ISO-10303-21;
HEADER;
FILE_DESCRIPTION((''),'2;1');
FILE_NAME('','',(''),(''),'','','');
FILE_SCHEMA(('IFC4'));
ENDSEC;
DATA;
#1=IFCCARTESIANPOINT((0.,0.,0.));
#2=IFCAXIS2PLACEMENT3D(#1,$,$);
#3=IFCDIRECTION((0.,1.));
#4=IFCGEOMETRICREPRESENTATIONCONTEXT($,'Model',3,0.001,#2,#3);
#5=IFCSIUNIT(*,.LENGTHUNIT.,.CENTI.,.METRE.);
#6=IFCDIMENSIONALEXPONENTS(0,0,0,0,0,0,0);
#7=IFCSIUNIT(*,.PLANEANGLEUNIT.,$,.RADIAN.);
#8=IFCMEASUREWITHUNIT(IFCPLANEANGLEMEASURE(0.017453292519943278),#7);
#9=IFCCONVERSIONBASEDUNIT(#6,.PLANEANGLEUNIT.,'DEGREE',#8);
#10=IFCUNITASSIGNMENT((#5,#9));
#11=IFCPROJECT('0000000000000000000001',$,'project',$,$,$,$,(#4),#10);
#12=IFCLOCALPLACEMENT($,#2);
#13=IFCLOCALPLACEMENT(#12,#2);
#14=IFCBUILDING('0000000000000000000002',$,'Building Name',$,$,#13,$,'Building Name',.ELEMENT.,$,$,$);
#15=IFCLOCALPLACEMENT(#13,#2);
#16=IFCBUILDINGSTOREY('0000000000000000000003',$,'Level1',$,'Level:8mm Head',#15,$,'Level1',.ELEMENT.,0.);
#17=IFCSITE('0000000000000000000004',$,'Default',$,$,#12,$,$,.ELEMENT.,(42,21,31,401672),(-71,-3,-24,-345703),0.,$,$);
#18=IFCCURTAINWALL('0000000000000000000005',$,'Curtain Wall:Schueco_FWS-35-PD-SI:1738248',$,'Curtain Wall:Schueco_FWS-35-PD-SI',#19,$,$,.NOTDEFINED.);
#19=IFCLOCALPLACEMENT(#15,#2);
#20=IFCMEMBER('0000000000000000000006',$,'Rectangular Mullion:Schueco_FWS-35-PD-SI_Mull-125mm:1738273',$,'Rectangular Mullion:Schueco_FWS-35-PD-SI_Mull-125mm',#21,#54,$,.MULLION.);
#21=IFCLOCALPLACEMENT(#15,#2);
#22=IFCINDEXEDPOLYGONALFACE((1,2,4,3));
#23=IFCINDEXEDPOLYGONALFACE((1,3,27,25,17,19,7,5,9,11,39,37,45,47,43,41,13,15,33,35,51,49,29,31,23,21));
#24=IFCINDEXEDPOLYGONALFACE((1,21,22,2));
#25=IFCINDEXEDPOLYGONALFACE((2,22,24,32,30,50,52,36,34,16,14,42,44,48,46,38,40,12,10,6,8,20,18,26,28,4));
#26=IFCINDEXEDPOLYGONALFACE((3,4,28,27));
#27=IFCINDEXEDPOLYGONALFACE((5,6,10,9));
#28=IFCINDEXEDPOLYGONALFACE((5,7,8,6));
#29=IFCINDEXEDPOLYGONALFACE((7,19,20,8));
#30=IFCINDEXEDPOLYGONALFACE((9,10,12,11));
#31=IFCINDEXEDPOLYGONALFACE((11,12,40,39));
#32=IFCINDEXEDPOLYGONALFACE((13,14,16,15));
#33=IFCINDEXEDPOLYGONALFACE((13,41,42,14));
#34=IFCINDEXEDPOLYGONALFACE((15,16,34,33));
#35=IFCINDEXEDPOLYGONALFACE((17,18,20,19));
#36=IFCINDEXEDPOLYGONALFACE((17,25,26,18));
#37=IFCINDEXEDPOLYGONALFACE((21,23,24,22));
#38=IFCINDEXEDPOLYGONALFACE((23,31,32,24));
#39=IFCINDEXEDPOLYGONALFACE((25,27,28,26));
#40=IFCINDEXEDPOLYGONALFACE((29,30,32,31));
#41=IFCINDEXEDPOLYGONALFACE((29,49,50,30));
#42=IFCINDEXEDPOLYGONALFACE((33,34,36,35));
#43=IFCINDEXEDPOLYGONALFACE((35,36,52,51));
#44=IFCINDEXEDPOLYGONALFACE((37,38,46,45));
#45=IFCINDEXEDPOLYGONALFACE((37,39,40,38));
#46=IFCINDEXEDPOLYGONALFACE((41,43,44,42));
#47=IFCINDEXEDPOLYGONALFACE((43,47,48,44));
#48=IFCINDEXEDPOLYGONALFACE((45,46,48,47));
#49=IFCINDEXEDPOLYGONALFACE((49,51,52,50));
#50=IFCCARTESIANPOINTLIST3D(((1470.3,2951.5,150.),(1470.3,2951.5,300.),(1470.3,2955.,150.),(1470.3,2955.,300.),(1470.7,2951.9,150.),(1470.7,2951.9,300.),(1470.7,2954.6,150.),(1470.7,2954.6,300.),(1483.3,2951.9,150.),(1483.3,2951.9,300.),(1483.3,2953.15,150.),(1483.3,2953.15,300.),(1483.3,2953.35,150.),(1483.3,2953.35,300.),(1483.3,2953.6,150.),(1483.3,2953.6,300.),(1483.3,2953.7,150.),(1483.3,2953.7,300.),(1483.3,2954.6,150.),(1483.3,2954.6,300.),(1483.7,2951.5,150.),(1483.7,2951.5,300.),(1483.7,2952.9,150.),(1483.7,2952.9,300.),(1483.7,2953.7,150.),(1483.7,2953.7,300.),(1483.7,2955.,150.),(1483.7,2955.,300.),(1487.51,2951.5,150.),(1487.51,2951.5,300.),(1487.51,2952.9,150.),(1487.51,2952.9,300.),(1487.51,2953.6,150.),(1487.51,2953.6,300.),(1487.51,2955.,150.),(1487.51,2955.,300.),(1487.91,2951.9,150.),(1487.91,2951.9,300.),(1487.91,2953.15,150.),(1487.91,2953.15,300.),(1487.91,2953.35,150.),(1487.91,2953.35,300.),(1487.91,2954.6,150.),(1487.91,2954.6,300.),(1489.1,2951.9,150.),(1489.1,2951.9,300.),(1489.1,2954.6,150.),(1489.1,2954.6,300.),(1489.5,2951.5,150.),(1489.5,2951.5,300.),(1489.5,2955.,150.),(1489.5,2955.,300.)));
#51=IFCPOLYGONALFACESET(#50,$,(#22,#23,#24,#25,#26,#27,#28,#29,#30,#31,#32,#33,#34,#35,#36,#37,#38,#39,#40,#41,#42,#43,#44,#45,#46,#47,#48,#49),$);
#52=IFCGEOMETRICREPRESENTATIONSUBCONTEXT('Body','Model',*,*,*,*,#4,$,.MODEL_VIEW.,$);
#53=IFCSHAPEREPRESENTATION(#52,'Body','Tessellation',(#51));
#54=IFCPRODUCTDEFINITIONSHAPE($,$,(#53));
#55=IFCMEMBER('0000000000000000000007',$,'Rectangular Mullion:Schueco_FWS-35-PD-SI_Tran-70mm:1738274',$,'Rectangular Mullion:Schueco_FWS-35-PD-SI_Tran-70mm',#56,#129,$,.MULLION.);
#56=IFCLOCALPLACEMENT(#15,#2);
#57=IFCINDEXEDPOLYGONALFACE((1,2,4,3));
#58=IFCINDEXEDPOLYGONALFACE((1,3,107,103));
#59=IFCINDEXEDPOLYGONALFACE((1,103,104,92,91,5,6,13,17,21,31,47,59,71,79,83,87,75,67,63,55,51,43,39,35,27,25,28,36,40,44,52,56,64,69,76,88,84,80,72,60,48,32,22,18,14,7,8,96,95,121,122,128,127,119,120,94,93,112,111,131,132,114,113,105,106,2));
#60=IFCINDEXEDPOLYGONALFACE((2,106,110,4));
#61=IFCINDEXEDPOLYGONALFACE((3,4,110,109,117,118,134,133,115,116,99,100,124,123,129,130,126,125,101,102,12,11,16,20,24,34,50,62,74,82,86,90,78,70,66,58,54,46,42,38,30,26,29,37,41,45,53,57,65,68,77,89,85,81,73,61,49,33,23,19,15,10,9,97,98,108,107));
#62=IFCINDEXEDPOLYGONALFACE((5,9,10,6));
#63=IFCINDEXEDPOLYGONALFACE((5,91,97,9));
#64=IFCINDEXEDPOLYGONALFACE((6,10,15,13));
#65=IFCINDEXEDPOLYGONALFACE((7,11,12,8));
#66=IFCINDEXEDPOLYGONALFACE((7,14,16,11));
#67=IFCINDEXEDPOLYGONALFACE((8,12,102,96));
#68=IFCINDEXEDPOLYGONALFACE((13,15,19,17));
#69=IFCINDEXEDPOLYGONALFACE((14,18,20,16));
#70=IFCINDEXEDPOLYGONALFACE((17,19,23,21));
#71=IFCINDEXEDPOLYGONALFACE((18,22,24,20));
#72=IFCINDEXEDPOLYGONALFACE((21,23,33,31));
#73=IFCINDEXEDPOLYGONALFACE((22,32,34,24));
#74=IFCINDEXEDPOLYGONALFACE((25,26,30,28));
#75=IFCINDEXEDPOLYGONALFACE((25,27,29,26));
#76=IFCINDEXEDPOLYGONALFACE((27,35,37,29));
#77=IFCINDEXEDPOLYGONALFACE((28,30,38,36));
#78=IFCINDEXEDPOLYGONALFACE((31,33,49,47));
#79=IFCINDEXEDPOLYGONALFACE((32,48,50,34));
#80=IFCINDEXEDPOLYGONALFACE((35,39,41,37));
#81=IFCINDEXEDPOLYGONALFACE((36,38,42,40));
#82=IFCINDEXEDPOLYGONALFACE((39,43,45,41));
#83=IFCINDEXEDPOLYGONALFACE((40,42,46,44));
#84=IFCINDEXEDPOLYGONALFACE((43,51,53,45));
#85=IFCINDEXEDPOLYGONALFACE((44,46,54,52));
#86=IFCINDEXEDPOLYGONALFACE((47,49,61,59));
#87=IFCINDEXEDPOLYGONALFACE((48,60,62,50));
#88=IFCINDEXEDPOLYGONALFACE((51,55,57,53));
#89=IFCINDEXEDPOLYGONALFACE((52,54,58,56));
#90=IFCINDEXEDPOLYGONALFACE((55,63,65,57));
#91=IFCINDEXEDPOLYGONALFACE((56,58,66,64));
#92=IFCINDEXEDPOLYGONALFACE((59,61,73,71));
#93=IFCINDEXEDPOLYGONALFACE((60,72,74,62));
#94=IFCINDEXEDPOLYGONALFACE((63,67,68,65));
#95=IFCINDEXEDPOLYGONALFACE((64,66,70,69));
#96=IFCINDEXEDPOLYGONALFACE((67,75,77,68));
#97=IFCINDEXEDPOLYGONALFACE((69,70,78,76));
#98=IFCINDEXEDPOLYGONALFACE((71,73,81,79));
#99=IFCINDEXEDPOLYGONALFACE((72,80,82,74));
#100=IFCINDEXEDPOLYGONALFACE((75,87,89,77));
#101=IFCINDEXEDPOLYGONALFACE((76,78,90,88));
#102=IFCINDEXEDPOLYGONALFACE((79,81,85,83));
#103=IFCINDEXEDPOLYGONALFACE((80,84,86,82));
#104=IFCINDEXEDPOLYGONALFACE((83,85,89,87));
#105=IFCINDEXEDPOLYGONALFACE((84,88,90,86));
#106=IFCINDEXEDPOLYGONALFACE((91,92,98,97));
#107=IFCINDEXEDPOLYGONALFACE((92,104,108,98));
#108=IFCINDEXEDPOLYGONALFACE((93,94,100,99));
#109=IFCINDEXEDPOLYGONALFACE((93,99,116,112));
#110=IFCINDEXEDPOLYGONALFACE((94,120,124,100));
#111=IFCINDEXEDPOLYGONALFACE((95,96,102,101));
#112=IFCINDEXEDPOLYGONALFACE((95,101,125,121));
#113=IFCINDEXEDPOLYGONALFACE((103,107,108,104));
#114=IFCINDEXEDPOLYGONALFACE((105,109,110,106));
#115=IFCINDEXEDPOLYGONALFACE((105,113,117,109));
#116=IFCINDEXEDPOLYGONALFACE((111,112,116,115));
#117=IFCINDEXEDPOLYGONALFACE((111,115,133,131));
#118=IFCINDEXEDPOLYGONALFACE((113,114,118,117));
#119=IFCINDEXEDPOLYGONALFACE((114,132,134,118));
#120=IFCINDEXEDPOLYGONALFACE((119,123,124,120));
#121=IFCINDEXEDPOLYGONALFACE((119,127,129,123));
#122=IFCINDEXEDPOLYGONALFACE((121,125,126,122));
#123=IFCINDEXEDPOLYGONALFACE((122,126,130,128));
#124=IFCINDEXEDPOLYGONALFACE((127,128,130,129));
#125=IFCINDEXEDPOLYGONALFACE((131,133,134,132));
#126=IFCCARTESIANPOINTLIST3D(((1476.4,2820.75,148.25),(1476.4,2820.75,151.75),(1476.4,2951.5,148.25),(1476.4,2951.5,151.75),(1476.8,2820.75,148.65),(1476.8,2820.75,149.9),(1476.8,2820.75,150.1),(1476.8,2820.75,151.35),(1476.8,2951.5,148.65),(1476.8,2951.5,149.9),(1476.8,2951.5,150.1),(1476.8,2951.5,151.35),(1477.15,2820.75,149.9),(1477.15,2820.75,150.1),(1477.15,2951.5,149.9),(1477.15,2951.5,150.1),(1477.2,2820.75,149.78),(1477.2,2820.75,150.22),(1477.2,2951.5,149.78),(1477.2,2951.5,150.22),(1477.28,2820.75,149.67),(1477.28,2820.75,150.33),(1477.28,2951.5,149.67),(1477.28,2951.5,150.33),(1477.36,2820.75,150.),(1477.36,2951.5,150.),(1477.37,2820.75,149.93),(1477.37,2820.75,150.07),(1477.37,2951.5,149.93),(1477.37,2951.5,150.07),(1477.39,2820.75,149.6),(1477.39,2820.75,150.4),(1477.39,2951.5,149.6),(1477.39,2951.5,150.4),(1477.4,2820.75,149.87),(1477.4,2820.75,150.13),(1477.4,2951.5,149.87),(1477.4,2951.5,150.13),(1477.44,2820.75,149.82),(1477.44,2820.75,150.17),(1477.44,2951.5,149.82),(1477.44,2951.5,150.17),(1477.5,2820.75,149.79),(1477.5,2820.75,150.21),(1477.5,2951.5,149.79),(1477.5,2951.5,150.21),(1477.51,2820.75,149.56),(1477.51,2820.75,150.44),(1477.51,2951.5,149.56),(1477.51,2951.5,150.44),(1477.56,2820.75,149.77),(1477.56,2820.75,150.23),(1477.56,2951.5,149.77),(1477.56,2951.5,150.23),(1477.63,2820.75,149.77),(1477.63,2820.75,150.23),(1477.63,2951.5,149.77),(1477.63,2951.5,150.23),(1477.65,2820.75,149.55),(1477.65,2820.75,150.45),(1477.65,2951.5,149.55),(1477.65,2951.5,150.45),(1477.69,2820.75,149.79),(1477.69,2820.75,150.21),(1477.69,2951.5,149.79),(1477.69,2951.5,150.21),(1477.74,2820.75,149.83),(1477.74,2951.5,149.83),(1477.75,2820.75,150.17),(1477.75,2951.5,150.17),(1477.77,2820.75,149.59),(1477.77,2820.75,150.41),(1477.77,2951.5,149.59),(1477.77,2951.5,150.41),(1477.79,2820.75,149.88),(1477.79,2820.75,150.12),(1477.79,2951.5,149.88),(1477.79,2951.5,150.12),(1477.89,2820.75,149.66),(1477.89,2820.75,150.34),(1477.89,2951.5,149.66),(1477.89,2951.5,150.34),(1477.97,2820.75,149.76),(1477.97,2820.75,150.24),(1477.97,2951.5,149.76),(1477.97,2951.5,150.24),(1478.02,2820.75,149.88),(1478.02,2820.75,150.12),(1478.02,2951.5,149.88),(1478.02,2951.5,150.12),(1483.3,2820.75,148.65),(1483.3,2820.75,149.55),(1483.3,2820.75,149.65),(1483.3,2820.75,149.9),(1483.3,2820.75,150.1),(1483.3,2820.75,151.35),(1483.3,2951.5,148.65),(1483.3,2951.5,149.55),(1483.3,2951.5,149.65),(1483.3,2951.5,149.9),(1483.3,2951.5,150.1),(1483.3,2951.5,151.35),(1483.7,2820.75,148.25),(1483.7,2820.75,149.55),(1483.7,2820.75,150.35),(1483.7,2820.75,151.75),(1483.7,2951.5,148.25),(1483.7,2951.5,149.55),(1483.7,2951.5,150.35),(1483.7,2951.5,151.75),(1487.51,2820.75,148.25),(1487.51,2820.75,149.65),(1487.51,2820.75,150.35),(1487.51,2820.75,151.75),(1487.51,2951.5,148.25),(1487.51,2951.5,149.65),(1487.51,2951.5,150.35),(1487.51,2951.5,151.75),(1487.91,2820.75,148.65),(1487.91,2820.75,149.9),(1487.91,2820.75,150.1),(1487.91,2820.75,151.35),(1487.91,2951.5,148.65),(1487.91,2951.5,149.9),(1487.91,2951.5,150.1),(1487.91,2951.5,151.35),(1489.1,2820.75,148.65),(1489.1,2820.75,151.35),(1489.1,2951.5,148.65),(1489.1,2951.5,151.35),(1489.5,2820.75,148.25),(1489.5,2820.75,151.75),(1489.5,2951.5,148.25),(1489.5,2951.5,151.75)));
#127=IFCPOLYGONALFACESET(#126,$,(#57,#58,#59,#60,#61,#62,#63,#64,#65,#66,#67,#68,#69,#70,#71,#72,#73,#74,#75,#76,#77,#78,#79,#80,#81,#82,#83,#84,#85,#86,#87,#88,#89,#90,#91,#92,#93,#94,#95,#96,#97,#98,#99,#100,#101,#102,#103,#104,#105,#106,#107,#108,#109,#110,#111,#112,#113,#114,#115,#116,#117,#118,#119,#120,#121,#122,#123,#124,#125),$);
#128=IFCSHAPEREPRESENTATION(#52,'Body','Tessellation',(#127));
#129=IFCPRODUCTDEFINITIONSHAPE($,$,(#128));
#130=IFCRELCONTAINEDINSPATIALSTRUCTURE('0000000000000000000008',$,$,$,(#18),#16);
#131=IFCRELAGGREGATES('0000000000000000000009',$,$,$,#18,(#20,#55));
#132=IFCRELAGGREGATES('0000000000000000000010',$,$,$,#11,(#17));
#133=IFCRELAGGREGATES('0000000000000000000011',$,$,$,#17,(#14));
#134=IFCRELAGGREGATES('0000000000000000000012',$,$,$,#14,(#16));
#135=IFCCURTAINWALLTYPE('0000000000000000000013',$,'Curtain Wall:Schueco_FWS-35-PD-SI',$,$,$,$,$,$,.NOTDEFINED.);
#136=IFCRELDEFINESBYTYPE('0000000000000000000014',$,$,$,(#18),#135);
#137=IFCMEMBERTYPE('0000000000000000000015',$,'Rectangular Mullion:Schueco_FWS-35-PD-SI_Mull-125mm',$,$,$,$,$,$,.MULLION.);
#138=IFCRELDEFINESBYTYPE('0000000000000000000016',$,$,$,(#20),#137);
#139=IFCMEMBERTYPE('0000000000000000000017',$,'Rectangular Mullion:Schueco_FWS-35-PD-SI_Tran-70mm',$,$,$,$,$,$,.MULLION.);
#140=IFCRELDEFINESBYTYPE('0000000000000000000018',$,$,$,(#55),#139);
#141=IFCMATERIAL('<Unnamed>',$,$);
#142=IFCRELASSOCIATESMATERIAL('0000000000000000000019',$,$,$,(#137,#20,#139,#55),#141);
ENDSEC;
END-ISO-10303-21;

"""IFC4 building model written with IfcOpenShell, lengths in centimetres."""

from ifc_helpers import new_model, entity, si_unit, converted_unit, direction, frame, origin, place, context, subcontext, project, spatial, line, arc, indexed_curve, outline, extrude, source, transform, mapped, material, type_object, type_shapes, element, aggregate, save


model = new_model("IFC4")

# Units and contexts
model_context = context("Model", 3, precision=0.001, world=origin(), true_north=direction((0.0, 1.0)))
body_context = subcontext(model_context, "Body", "Model", "MODEL_VIEW")
ifc_project = project(units=[si_unit("LENGTHUNIT", "METRE", prefix="CENTI"), converted_unit("PLANEANGLEUNIT", "DEGREE", entity("IfcPlaneAngleMeasure", 0.017453292519943278), si_unit("PLANEANGLEUNIT", "RADIAN"), dimensions=[0, 0, 0, 0, 0, 0, 0])], contexts=[model_context])

# Site, building, storey
site_placement = place(None, origin())
site = spatial("IfcSite", under=ifc_project, at=site_placement, Name="Default", CompositionType="ELEMENT", RefLatitude=(42, 21, 31, 401672), RefLongitude=(-71, -3, -24, -345703), RefElevation=0.0)
building_placement = place(site_placement, origin())
building = spatial("IfcBuilding", under=site, at=building_placement, Name="Building Name", LongName="Building Name", CompositionType="ELEMENT")
storey_placement = place(building_placement, origin())
storey = spatial("IfcBuildingStorey", under=building, at=storey_placement, Name="Level1", ObjectType="Level:8mm Head", LongName="Level1", CompositionType="ELEMENT", Elevation=0.0)

# Curtain wall, members
curtain_wall_type = type_object("IfcCurtainWallType", Name="Curtain Wall:Schueco_FWS-35-PD-SI", PredefinedType="NOTDEFINED")
curtain_wall_placement = place(storey_placement, origin())
curtain_wall = element("IfcCurtainWall", 1, at=curtain_wall_placement, inside=storey, type_object=curtain_wall_type, Name="Curtain Wall:Schueco_FWS-35-PD-SI:1738248", ObjectType="Curtain Wall:Schueco_FWS-35-PD-SI", PredefinedType="NOTDEFINED")
ifc_material_1 = material(Name="<Unnamed>")
member_type_1 = type_object("IfcMemberType", Name="Rectangular Mullion:Schueco_FWS-35-PD-SI_Mull-125mm", PredefinedType="MULLION", material=ifc_material_1)
shared_shape_1 = source(origin(), body_context, "Body", "SweptSolid", [
    extrude(outline(indexed_curve([(-13.37, -1.78), (0.03, -1.78), (0.03, -0.38), (3.84, -0.38), (3.84, -1.78), (5.83, -1.78), (5.83, 1.72), (3.84, 1.72), (3.84, 0.32), (-0.37, 0.32), (-0.37, 0.07), (4.24, 0.07), (4.24, 1.32), (5.43, 1.32), (5.43, -1.38), (4.24, -1.38), (4.24, -0.13), (-0.37, -0.13), (-0.37, -1.38), (-12.97, -1.38), (-12.97, 1.32), (-0.37, 1.32), (-0.37, 0.42), (0.03, 0.42), (0.03, 1.72), (-13.37, 1.72), (-13.37, -1.78)], self_intersect=False)), frame((-1.72, 3.83, -150.0), z_axis=(0.0, 0.0, 1.0), x_axis=(0.0, -1.0, 0.0)), (0.0, 0.0, 1.0), 150.0),
])
type_shapes(member_type_1, [shared_shape_1])
member_1_placement = place(curtain_wall_placement, frame((1487.5, 2955.0, 300.0), z_axis=(0.0, 0.0, 1.0), x_axis=(0.0, 1.0, 0.0)))
member_1 = element("IfcMember", 2, at=member_1_placement, type_object=member_type_1, material=ifc_material_1, Name="Rectangular Mullion:Schueco_FWS-35-PD-SI_Mull-125mm:1738273", ObjectType="Rectangular Mullion:Schueco_FWS-35-PD-SI_Mull-125mm", PredefinedType="MULLION", context=body_context, shape_type="MappedRepresentation", body=[
    mapped(shared_shape_1, transform((0.0, 0.0, 0.0), scale=1.0)),
])
member_type_2 = type_object("IfcMemberType", Name="Rectangular Mullion:Schueco_FWS-35-PD-SI_Tran-70mm", PredefinedType="MULLION", material=ifc_material_1)
shared_shape_2 = source(origin(), body_context, "Body", "SweptSolid", [
    extrude(outline(indexed_curve([(-1.78, -6.52), (1.72, -6.52), (1.72, 0.78), (0.42, 0.78), (0.42, 0.38), (1.32, 0.38), (1.32, -6.12), (0.07, -6.12), (0.07, -5.77), (0.42, -5.34), (0.09, -4.9), (0.09, -5.14), (-0.03, -5.56), (-0.15, -5.14), (-0.15, -4.9), (-0.48, -5.34), (-0.13, -5.77), (-0.13, -6.12), (-1.38, -6.12), (-1.38, 0.38), (-0.13, 0.38), (-0.13, 4.99), (-1.38, 4.99), (-1.38, 6.18), (1.32, 6.18), (1.32, 4.99), (0.07, 4.99), (0.07, 0.38), (0.32, 0.38), (0.32, 4.59), (1.72, 4.59), (1.72, 6.58), (-1.78, 6.58), (-1.78, 4.59), (-0.38, 4.59), (-0.38, 0.78), (-1.78, 0.78)], segments=[line(1, 2, 3, 4, 5, 6, 7, 8, 9), arc(9, 10, 11), line(11, 12), arc(12, 13, 14), line(14, 15), arc(15, 16, 17), line(17, 18, 19, 20, 21, 22, 23, 24, 25, 26, 27, 28, 29, 30, 31, 32, 33, 34, 35, 36, 37, 1)], self_intersect=False)), frame((-0.03, 4.58, -130.75), z_axis=(0.0, 0.0, 1.0), x_axis=(-1.0, 0.0, 0.0)), (0.0, 0.0, 1.0), 130.75),
])
type_shapes(member_type_2, [shared_shape_2])
member_2_placement = place(curtain_wall_placement, frame((1487.5, 2820.75, 150.0), z_axis=(0.0, -1.0, 0.0), x_axis=(0.0, 0.0, 1.0)))
member_2 = element("IfcMember", 3, at=member_2_placement, type_object=member_type_2, material=ifc_material_1, Name="Rectangular Mullion:Schueco_FWS-35-PD-SI_Tran-70mm:1738274", ObjectType="Rectangular Mullion:Schueco_FWS-35-PD-SI_Tran-70mm", PredefinedType="MULLION", context=body_context, shape_type="MappedRepresentation", body=[
    mapped(shared_shape_2, transform((0.0, 0.0, 0.0), scale=1.0)),
])
aggregate(curtain_wall, [member_1, member_2])

save(model, "model.ifc")
